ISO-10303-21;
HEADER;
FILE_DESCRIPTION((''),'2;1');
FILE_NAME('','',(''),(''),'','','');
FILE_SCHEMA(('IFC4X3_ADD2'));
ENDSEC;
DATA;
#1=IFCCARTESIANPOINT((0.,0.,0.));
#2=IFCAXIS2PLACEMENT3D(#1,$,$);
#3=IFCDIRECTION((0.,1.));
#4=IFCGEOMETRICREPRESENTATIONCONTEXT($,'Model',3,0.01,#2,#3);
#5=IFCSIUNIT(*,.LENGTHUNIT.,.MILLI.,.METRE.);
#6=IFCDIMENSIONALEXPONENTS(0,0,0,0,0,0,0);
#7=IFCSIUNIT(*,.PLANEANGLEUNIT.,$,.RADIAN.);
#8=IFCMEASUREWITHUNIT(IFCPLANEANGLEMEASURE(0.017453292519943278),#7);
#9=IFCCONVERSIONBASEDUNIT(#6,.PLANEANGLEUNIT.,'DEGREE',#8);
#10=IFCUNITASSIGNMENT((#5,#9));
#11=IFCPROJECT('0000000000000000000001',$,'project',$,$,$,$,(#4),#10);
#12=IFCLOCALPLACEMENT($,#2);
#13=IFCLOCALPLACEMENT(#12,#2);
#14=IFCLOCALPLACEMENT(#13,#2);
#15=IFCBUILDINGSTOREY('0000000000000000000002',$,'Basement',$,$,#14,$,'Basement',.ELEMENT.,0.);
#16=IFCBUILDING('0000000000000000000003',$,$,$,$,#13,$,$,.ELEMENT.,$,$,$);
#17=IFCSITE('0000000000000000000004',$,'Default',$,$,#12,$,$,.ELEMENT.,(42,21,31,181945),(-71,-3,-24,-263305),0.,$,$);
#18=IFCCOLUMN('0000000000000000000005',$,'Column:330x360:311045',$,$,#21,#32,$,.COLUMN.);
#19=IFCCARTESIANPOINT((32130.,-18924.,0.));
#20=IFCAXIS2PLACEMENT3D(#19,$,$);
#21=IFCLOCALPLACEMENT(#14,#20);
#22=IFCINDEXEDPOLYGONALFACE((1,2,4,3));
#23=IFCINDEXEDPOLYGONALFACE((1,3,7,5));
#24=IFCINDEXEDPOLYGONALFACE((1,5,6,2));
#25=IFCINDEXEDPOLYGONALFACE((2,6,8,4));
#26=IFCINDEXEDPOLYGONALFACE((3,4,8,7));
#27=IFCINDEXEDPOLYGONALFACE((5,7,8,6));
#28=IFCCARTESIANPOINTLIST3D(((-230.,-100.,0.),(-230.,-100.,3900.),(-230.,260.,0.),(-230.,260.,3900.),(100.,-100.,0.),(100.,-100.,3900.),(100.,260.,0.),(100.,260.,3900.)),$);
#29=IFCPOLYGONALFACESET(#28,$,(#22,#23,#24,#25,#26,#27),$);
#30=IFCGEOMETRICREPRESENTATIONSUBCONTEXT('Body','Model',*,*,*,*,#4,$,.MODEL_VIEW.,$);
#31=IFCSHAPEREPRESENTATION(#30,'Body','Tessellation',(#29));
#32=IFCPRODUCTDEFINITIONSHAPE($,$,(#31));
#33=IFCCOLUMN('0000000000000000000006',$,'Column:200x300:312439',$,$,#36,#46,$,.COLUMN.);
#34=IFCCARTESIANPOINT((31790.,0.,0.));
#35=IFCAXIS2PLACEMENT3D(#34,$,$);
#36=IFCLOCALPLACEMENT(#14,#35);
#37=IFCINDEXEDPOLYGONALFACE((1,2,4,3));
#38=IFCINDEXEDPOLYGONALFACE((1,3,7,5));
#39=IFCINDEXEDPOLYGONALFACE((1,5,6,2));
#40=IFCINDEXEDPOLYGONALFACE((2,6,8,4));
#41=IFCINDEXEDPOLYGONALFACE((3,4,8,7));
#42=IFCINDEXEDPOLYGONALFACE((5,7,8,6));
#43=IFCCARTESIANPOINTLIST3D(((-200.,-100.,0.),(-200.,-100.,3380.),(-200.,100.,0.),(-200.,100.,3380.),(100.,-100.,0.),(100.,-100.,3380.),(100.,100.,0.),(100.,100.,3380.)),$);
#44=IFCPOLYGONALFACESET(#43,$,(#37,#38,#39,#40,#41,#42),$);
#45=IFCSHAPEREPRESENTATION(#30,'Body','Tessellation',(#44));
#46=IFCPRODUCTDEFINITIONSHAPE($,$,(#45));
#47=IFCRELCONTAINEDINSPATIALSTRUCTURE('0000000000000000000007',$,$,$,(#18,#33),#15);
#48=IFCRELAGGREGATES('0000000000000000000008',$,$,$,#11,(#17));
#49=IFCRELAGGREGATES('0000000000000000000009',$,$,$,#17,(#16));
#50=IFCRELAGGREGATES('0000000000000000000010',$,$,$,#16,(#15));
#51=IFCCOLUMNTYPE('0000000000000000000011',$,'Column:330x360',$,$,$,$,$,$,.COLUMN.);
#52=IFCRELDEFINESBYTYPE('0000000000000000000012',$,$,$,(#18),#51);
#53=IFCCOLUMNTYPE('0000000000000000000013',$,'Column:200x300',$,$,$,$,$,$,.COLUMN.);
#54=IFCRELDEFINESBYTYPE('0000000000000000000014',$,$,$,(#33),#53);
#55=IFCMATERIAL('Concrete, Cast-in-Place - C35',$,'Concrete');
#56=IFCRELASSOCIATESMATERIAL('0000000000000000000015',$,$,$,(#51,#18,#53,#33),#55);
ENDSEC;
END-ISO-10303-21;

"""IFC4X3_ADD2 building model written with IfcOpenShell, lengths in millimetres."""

from ifc_helpers import new_model, entity, si_unit, converted_unit, direction, frame, origin, origin_2d_with_axis, place, context, subcontext, project, spatial, rectangle, extrude, source, transform, mapped, material, material_profile, profile_set, profile_usage, type_object, type_shapes, element, save


model = new_model("IFC4X3_ADD2")

# Units and contexts
model_context = context("Model", 3, precision=0.01, world=origin(), true_north=direction((0.0, 1.0)))
body_context = subcontext(model_context, "Body", "Model", "MODEL_VIEW")
ifc_project = project(units=[si_unit("LENGTHUNIT", "METRE", prefix="MILLI"), converted_unit("PLANEANGLEUNIT", "DEGREE", entity("IfcPlaneAngleMeasure", 0.017453292519943278), si_unit("PLANEANGLEUNIT", "RADIAN"), dimensions=[0, 0, 0, 0, 0, 0, 0])], contexts=[model_context])

# Site, building, storey
site_placement = place(None, origin())
site = spatial("IfcSite", under=ifc_project, at=site_placement, Name="Default", CompositionType="ELEMENT", RefLatitude=(42, 21, 31, 181945), RefLongitude=(-71, -3, -24, -263305), RefElevation=0.0)
building_placement = place(site_placement, origin())
building = spatial("IfcBuilding", under=site, at=building_placement, CompositionType="ELEMENT")
storey_placement = place(building_placement, origin())
storey = spatial("IfcBuildingStorey", under=building, at=storey_placement, Name="Basement", LongName="Basement", CompositionType="ELEMENT", Elevation=0.0)

# Columns
ifc_material = material(Name="Concrete, Cast-in-Place - C35", Category="Concrete")
ifc_material_profile_1 = material_profile(ifc_material, rectangle(XDim=330.0, YDim=360.0, at=origin_2d_with_axis()), Name="330x360")
ifc_profile_set_1 = profile_set([ifc_material_profile_1], Name="330x360")
ifc_profile_usage_1 = profile_usage(ifc_profile_set_1)
column_type_1 = type_object("IfcColumnType", Name="Column:330x360", PredefinedType="COLUMN", material=ifc_profile_set_1)
shared_shape_1 = source(origin(), body_context, "Body", "SweptSolid", [
    extrude(rectangle(XDim=330.0, YDim=360.0, at=origin_2d_with_axis()), frame((-65.0, 80.0, 0.0), z_axis=(0.0, 0.0, 1.0), x_axis=(-1.0, 0.0, 0.0)), (0.0, 0.0, 1.0), 3900.0),
])
type_shapes(column_type_1, [shared_shape_1])
column_1_placement = place(storey_placement, frame((32130.0, -18924.0, 0.0)))
element("IfcColumn", 1, at=column_1_placement, inside=storey, type_object=column_type_1, material=ifc_profile_usage_1, Name="Column:330x360:311045", PredefinedType="COLUMN", context=body_context, shape_type="MappedRepresentation", body=[
    mapped(shared_shape_1, transform((0.0, 0.0, 0.0), scale=1.0)),
])
ifc_material_profile_2 = material_profile(ifc_material, rectangle(XDim=300.0, YDim=200.0, at=origin_2d_with_axis()), Name="200x300")
ifc_profile_set_2 = profile_set([ifc_material_profile_2], Name="200x300")
ifc_profile_usage_2 = profile_usage(ifc_profile_set_2)
column_type_2 = type_object("IfcColumnType", Name="Column:200x300", PredefinedType="COLUMN", material=ifc_profile_set_2)
shared_shape_2 = source(origin(), body_context, "Body", "SweptSolid", [
    extrude(rectangle(XDim=300.0, YDim=200.0, at=origin_2d_with_axis()), frame((-50.0, 0.0, 0.0), z_axis=(0.0, 0.0, 1.0), x_axis=(-1.0, 0.0, 0.0)), (0.0, 0.0, 1.0), 3380.0),
])
type_shapes(column_type_2, [shared_shape_2])
column_2_placement = place(storey_placement, frame((31790.0, 0.0, 0.0)))
element("IfcColumn", 2, at=column_2_placement, inside=storey, type_object=column_type_2, material=ifc_profile_usage_2, Name="Column:200x300:312439", PredefinedType="COLUMN", context=body_context, shape_type="MappedRepresentation", body=[
    mapped(shared_shape_2, transform((0.0, 0.0, 0.0), scale=1.0)),
])

save(model, "model.ifc")
